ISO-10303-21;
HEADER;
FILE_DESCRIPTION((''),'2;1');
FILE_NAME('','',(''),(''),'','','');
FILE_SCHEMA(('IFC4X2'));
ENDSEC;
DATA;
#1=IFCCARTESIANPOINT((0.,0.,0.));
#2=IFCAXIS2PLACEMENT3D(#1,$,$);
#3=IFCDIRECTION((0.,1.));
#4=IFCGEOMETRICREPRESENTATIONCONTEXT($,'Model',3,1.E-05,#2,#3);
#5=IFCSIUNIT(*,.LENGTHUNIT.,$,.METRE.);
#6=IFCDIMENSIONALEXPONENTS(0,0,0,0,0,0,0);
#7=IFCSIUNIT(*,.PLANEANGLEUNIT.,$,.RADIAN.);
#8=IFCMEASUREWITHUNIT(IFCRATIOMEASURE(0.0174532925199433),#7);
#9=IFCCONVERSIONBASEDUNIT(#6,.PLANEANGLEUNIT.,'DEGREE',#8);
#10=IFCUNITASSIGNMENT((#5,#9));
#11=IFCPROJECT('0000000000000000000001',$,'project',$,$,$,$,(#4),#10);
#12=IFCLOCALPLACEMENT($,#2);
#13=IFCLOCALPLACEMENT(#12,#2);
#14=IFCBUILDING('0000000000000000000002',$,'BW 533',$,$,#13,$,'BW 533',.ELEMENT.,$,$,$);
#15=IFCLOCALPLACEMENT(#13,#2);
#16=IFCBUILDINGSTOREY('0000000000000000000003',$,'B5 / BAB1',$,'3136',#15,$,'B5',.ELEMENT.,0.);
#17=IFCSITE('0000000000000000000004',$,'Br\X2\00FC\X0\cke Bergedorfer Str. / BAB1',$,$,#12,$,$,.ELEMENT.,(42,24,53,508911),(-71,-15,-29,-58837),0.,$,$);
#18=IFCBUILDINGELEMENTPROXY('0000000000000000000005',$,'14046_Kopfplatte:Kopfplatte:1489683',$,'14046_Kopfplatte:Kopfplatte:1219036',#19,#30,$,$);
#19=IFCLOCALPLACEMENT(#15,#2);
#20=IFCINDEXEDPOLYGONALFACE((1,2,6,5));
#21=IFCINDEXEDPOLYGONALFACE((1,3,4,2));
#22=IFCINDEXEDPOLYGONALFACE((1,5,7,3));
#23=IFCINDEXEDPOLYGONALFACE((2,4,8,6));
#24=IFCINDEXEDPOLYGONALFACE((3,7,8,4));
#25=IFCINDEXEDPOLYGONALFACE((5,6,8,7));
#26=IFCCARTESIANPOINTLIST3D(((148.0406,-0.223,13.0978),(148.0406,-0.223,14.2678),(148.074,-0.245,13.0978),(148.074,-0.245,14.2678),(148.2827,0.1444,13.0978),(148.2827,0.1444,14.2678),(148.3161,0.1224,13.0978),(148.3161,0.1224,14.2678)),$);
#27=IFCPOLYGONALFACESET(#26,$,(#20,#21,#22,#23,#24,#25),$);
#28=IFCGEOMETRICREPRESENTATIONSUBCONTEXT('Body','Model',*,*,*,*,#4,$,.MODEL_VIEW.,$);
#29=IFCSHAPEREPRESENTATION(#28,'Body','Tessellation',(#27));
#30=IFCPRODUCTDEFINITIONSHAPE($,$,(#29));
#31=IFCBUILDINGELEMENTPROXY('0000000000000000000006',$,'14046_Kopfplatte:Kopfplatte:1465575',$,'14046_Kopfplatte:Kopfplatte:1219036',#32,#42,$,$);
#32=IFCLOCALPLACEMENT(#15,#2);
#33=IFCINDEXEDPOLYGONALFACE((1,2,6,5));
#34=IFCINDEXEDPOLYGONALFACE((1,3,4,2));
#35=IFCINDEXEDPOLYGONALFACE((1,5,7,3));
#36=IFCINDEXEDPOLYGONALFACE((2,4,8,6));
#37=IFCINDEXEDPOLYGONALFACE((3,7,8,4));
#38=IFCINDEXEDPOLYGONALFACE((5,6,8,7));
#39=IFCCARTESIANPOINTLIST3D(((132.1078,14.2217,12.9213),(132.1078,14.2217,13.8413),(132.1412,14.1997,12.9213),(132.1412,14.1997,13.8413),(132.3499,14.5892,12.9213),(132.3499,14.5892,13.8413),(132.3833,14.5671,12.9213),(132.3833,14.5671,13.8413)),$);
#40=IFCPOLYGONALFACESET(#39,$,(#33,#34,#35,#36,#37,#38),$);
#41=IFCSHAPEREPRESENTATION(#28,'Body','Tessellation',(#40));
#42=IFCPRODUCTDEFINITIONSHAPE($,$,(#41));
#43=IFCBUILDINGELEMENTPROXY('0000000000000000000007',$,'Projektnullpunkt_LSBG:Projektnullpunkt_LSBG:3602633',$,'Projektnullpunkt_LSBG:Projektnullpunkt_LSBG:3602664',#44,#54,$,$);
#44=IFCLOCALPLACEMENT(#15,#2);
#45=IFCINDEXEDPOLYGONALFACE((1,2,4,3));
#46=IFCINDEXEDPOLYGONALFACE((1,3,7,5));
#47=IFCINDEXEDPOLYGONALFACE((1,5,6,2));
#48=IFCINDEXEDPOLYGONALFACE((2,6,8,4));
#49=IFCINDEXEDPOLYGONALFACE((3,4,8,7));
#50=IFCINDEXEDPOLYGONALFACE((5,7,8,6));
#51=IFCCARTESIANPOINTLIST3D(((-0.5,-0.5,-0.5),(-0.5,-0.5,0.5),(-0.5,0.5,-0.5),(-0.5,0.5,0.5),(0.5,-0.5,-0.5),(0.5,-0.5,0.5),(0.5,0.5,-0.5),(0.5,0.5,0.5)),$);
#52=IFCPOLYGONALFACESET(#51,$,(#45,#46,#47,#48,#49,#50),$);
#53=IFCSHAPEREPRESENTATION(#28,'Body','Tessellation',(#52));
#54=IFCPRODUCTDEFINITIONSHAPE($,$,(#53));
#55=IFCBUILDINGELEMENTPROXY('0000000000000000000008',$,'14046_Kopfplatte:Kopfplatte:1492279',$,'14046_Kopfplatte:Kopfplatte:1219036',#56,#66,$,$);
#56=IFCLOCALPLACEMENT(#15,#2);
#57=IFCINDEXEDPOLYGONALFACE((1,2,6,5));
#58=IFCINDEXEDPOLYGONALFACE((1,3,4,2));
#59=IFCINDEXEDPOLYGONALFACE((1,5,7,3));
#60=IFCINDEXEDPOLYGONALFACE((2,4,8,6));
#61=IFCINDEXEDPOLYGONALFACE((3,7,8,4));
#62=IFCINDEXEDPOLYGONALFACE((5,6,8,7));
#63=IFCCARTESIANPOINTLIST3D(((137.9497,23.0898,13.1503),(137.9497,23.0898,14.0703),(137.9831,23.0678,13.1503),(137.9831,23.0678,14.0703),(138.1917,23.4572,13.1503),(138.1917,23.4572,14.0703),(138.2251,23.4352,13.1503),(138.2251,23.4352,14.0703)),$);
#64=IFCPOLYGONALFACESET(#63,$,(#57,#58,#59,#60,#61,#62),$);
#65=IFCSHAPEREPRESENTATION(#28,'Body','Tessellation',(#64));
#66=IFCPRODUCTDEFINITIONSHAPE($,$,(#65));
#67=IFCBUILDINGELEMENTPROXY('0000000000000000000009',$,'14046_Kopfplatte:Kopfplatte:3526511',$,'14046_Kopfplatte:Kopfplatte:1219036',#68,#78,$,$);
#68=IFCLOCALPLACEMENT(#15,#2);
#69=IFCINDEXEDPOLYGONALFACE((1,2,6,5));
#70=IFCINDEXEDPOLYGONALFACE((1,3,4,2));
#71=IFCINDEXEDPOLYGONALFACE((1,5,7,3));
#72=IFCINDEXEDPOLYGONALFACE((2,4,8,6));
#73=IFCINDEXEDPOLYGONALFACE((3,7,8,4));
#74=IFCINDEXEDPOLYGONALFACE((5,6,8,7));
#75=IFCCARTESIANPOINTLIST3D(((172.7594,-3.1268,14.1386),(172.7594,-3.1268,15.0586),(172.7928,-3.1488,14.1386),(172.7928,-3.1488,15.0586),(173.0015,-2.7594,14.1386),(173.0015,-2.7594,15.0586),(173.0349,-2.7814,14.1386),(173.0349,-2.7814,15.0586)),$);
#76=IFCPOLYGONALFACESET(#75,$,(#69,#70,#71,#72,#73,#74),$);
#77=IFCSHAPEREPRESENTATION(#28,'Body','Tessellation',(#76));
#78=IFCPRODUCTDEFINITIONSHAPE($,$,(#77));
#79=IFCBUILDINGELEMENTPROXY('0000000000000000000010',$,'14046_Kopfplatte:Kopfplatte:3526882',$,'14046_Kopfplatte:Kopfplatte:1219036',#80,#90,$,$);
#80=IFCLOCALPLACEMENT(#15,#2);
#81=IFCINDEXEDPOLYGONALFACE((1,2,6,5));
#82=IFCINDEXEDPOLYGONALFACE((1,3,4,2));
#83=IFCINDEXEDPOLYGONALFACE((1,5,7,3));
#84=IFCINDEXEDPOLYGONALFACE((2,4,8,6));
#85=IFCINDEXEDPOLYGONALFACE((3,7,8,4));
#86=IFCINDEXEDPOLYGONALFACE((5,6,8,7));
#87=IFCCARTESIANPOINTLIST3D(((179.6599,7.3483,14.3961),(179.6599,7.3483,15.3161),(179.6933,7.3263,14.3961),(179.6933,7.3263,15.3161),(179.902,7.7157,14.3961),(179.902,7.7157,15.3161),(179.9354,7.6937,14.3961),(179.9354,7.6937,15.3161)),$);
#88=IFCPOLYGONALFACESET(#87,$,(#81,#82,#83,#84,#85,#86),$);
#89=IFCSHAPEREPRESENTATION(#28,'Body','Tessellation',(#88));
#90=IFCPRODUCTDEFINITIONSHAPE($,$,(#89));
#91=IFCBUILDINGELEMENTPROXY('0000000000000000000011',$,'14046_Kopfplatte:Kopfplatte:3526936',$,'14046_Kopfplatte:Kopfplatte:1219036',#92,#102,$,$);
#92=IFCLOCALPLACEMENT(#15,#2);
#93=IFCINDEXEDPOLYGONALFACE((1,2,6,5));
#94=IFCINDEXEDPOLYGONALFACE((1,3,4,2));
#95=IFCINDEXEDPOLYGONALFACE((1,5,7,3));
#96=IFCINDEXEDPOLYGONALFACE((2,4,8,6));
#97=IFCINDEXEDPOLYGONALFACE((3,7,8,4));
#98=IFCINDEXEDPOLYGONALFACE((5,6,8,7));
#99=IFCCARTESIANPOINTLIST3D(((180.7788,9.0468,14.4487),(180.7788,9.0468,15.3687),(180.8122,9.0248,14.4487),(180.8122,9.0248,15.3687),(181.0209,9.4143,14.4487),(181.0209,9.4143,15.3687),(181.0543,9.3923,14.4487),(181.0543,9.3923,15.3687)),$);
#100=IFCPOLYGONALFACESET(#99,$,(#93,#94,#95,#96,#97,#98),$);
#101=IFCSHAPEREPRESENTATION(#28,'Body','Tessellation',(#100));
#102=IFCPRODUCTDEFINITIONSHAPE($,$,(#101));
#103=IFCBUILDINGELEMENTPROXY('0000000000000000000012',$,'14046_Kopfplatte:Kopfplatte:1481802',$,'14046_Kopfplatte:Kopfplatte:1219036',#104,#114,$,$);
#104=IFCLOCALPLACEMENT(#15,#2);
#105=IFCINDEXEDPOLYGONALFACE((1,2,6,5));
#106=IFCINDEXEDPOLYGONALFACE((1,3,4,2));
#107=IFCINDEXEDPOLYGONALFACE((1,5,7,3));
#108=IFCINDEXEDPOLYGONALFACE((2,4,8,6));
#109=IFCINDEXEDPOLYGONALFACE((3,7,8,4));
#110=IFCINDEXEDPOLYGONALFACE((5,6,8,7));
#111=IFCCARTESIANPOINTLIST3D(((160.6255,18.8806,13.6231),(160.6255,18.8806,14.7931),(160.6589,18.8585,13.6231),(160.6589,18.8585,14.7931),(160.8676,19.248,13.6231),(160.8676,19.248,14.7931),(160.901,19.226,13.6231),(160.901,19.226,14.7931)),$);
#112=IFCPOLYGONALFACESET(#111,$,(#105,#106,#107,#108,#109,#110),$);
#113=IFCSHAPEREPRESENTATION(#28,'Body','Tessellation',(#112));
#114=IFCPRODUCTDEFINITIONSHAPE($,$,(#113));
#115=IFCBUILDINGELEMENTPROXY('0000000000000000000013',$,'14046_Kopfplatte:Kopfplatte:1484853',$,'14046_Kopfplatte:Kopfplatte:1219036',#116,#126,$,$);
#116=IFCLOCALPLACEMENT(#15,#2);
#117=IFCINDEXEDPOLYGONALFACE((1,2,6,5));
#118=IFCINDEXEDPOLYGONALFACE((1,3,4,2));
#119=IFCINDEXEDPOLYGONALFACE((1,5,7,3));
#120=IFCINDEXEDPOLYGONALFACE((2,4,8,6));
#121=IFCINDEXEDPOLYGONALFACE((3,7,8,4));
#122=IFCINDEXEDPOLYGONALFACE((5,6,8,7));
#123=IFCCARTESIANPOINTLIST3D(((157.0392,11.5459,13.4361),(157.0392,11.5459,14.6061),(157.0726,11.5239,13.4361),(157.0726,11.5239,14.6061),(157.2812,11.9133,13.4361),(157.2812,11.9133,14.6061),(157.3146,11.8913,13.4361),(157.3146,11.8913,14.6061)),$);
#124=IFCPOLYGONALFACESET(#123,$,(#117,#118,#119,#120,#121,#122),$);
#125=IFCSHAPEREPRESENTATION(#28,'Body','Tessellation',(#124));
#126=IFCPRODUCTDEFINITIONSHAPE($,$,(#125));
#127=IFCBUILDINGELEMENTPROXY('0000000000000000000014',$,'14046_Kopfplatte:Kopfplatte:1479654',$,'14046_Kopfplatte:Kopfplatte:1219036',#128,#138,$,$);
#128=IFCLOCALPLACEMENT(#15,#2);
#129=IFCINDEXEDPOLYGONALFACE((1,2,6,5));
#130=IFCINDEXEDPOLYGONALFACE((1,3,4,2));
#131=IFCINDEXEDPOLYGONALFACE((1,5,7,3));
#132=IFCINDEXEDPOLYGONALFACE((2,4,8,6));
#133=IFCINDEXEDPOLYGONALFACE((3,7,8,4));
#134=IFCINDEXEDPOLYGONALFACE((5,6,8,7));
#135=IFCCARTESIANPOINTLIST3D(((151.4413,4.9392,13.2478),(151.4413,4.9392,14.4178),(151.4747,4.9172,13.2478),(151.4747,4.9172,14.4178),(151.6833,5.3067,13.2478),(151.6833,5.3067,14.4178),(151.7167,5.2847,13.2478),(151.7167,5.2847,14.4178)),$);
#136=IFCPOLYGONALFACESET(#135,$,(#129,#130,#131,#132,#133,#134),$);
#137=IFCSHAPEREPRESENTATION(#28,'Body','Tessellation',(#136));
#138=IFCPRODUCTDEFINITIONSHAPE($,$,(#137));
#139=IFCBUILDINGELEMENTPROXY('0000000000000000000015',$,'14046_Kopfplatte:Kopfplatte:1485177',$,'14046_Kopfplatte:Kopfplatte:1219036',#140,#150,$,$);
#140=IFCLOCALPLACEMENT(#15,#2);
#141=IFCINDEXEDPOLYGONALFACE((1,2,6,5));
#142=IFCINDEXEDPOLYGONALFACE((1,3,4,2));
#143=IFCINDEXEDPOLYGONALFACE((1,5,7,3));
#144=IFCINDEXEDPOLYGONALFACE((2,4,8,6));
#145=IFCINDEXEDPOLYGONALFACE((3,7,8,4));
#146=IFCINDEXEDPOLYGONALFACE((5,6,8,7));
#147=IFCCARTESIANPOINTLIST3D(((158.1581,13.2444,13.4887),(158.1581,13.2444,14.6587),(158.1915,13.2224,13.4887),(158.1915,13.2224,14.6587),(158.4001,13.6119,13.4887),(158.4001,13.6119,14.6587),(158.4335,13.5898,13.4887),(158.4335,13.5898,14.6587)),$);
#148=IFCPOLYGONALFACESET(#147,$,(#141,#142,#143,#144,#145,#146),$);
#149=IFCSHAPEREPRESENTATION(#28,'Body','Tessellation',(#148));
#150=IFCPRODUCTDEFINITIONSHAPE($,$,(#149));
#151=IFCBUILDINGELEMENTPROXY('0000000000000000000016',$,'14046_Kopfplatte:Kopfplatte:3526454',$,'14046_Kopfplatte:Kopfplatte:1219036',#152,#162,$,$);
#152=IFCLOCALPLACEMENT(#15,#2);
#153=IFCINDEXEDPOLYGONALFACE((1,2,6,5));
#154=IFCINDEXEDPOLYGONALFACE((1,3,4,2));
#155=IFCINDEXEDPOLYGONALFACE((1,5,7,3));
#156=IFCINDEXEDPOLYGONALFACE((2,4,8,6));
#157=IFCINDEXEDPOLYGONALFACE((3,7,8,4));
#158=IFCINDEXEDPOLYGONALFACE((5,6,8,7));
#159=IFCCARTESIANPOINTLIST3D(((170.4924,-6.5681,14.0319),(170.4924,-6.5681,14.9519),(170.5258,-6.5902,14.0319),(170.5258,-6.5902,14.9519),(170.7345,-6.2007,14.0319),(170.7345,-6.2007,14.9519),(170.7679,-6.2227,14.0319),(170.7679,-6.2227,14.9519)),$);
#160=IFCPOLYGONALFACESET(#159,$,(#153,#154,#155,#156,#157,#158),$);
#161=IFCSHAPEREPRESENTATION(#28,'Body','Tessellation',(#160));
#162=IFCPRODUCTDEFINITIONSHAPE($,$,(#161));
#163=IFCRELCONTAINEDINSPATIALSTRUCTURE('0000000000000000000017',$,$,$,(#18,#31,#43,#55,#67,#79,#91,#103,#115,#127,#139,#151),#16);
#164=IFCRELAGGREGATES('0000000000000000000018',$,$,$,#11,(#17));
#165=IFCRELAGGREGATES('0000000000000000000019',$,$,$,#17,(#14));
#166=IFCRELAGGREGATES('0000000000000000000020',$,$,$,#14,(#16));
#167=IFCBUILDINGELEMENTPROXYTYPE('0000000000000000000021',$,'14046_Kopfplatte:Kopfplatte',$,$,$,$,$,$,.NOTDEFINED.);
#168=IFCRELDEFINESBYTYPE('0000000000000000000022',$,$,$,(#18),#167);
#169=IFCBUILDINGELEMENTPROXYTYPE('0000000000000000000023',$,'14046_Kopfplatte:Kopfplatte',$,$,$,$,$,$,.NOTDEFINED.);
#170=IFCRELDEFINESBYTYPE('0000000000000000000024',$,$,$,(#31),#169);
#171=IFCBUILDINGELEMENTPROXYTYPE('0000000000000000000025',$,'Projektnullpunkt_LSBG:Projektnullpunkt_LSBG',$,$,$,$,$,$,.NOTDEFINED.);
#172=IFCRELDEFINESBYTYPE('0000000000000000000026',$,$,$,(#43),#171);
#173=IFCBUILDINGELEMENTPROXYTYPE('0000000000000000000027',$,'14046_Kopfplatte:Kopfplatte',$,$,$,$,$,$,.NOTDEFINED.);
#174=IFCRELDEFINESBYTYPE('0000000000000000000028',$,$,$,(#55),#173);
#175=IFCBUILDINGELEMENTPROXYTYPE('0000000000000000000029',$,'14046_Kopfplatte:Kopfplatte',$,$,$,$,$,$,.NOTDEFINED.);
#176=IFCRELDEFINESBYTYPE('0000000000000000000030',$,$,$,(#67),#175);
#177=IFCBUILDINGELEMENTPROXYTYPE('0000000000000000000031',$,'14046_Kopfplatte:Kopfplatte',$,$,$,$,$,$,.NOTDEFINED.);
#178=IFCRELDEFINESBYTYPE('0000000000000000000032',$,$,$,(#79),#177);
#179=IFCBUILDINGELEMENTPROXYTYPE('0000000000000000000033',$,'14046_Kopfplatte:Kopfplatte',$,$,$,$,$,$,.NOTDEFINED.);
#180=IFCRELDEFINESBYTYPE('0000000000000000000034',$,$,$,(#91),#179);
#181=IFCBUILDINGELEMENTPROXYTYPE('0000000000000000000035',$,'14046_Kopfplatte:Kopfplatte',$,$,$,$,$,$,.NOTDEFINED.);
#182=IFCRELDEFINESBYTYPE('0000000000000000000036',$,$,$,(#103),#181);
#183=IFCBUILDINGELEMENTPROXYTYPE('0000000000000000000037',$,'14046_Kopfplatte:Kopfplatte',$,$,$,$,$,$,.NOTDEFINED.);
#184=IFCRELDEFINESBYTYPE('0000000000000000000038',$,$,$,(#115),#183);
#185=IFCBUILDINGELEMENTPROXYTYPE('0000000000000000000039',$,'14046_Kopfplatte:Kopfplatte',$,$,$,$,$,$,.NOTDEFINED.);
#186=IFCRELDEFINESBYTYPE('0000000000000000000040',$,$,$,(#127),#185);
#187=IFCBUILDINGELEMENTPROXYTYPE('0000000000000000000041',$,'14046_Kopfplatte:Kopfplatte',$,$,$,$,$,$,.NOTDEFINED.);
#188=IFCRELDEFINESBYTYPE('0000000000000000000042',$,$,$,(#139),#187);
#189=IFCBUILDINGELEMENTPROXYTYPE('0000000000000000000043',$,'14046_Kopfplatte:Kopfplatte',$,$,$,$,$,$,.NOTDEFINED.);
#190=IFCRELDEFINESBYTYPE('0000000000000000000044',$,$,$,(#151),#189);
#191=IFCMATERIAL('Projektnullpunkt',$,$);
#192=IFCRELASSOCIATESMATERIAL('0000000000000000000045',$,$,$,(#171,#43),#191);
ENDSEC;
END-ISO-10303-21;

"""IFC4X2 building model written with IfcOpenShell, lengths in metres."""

from ifc_helpers import new_model, entity, si_unit, converted_unit, direction, frame, frame_2d, origin, origin_2d_with_axis, place, context, subcontext, project, spatial, rectangle, extrude, source, transform, mapped, material, type_object, type_shapes, element, save


model = new_model("IFC4X2")

# Units and contexts
model_context = context("Model", 3, precision=1e-05, world=origin(), true_north=direction((0.0, 1.0)))
body_context = subcontext(model_context, "Body", "Model", "MODEL_VIEW")
ifc_project = project(units=[si_unit("LENGTHUNIT", "METRE"), converted_unit("PLANEANGLEUNIT", "DEGREE", entity("IfcRatioMeasure", 0.0174532925199433), si_unit("PLANEANGLEUNIT", "RADIAN"), dimensions=[0, 0, 0, 0, 0, 0, 0])], contexts=[model_context])

# Site, building, storey
site_placement = place(None, origin())
site = spatial("IfcSite", under=ifc_project, at=site_placement, Name="Brücke Bergedorfer Str. / BAB1", CompositionType="ELEMENT", RefLatitude=(42, 24, 53, 508911), RefLongitude=(-71, -15, -29, -58837), RefElevation=0.0)
building_placement = place(site_placement, origin())
building = spatial("IfcBuilding", under=site, at=building_placement, Name="BW 533", LongName="BW 533", CompositionType="ELEMENT")
storey_placement = place(building_placement, origin())
storey = spatial("IfcBuildingStorey", under=building, at=storey_placement, Name="B5 / BAB1", ObjectType="3136", LongName="B5", CompositionType="ELEMENT", Elevation=0.0)

# Building element proxies
building_element_proxy_type_1 = type_object("IfcBuildingElementProxyType", Name="14046_Kopfplatte:Kopfplatte", PredefinedType="NOTDEFINED")
shared_shape_1 = source(origin(), body_context, "Body", "SweptSolid", [
    extrude(rectangle(XDim=0.04, YDim=0.44, at=frame_2d((0.0, 0.0), x_axis=(1.0, 0.0))), frame((148.1784, -0.0503, 13.0978), z_axis=(0.0, 0.0, 1.0), x_axis=(0.835088, -0.550116, 0.0)), (0.0, 0.0, 1.0), 1.17),
])
type_shapes(building_element_proxy_type_1, [shared_shape_1])
proxy_1_placement = place(storey_placement, origin())
element("IfcBuildingElementProxy", 1, at=proxy_1_placement, inside=storey, type_object=building_element_proxy_type_1, Name="14046_Kopfplatte:Kopfplatte:1489683", ObjectType="14046_Kopfplatte:Kopfplatte:1219036", context=body_context, shape_type="MappedRepresentation", body=[
    mapped(shared_shape_1, transform((0.0, 0.0, 0.0), scale=1.0)),
])
building_element_proxy_type_2 = type_object("IfcBuildingElementProxyType", Name="14046_Kopfplatte:Kopfplatte", PredefinedType="NOTDEFINED")
shared_shape_2 = source(origin(), body_context, "Body", "SweptSolid", [
    extrude(rectangle(XDim=0.04, YDim=0.44, at=frame_2d((0.0, 0.0), x_axis=(1.0, 0.0))), frame((132.2456, 14.3944, 12.9213), z_axis=(0.0, 0.0, 1.0), x_axis=(-0.835088, 0.550116, 0.0)), (0.0, 0.0, 1.0), 0.92),
])
type_shapes(building_element_proxy_type_2, [shared_shape_2])
proxy_2_placement = place(storey_placement, origin())
element("IfcBuildingElementProxy", 2, at=proxy_2_placement, inside=storey, type_object=building_element_proxy_type_2, Name="14046_Kopfplatte:Kopfplatte:1465575", ObjectType="14046_Kopfplatte:Kopfplatte:1219036", context=body_context, shape_type="MappedRepresentation", body=[
    mapped(shared_shape_2, transform((0.0, 0.0, 0.0), scale=1.0)),
])
ifc_material_1 = material(Name="Projektnullpunkt")
building_element_proxy_type_3 = type_object("IfcBuildingElementProxyType", Name="Projektnullpunkt_LSBG:Projektnullpunkt_LSBG", PredefinedType="NOTDEFINED", material=ifc_material_1)
shared_shape_3 = source(origin(), body_context, "Body", "SweptSolid", [
    extrude(rectangle(XDim=1.0, YDim=1.0, at=origin_2d_with_axis()), frame((0.0, 0.0, -0.5), z_axis=(0.0, 0.0, 1.0), x_axis=(-1.0, 0.0, 0.0)), (0.0, 0.0, 1.0), 1.0),
])
type_shapes(building_element_proxy_type_3, [shared_shape_3])
proxy_3_placement = place(storey_placement, origin())
element("IfcBuildingElementProxy", 3, at=proxy_3_placement, inside=storey, type_object=building_element_proxy_type_3, material=ifc_material_1, Name="Projektnullpunkt_LSBG:Projektnullpunkt_LSBG:3602633", ObjectType="Projektnullpunkt_LSBG:Projektnullpunkt_LSBG:3602664", context=body_context, shape_type="MappedRepresentation", body=[
    mapped(shared_shape_3, transform((0.0, 0.0, 0.0), scale=1.0)),
])
building_element_proxy_type_4 = type_object("IfcBuildingElementProxyType", Name="14046_Kopfplatte:Kopfplatte", PredefinedType="NOTDEFINED")
shared_shape_4 = source(origin(), body_context, "Body", "SweptSolid", [
    extrude(rectangle(XDim=0.04, YDim=0.44, at=frame_2d((0.0, 0.0), x_axis=(1.0, 0.0))), frame((138.0874, 23.2625, 13.1503), z_axis=(0.0, 0.0, 1.0), x_axis=(-0.835088, 0.550116, 0.0)), (0.0, 0.0, 1.0), 0.92),
])
type_shapes(building_element_proxy_type_4, [shared_shape_4])
proxy_4_placement = place(storey_placement, origin())
element("IfcBuildingElementProxy", 4, at=proxy_4_placement, inside=storey, type_object=building_element_proxy_type_4, Name="14046_Kopfplatte:Kopfplatte:1492279", ObjectType="14046_Kopfplatte:Kopfplatte:1219036", context=body_context, shape_type="MappedRepresentation", body=[
    mapped(shared_shape_4, transform((0.0, 0.0, 0.0), scale=1.0)),
])
building_element_proxy_type_5 = type_object("IfcBuildingElementProxyType", Name="14046_Kopfplatte:Kopfplatte", PredefinedType="NOTDEFINED")
shared_shape_5 = source(origin(), body_context, "Body", "SweptSolid", [
    extrude(rectangle(XDim=0.04, YDim=0.44, at=frame_2d((0.0, 0.0), x_axis=(1.0, 0.0))), frame((172.8971, -2.9541, 14.1386), z_axis=(0.0, 0.0, 1.0), x_axis=(0.835088, -0.550116, 0.0)), (0.0, 0.0, 1.0), 0.92),
])
type_shapes(building_element_proxy_type_5, [shared_shape_5])
proxy_5_placement = place(storey_placement, origin())
element("IfcBuildingElementProxy", 5, at=proxy_5_placement, inside=storey, type_object=building_element_proxy_type_5, Name="14046_Kopfplatte:Kopfplatte:3526511", ObjectType="14046_Kopfplatte:Kopfplatte:1219036", context=body_context, shape_type="MappedRepresentation", body=[
    mapped(shared_shape_5, transform((0.0, 0.0, 0.0), scale=1.0)),
])
building_element_proxy_type_6 = type_object("IfcBuildingElementProxyType", Name="14046_Kopfplatte:Kopfplatte", PredefinedType="NOTDEFINED")
shared_shape_6 = source(origin(), body_context, "Body", "SweptSolid", [
    extrude(rectangle(XDim=0.04, YDim=0.44, at=frame_2d((0.0, 0.0), x_axis=(1.0, 0.0))), frame((179.7976, 7.521, 14.3961), z_axis=(0.0, 0.0, 1.0), x_axis=(0.835088, -0.550116, 0.0)), (0.0, 0.0, 1.0), 0.92),
])
type_shapes(building_element_proxy_type_6, [shared_shape_6])
proxy_6_placement = place(storey_placement, origin())
element("IfcBuildingElementProxy", 6, at=proxy_6_placement, inside=storey, type_object=building_element_proxy_type_6, Name="14046_Kopfplatte:Kopfplatte:3526882", ObjectType="14046_Kopfplatte:Kopfplatte:1219036", context=body_context, shape_type="MappedRepresentation", body=[
    mapped(shared_shape_6, transform((0.0, 0.0, 0.0), scale=1.0)),
])
building_element_proxy_type_7 = type_object("IfcBuildingElementProxyType", Name="14046_Kopfplatte:Kopfplatte", PredefinedType="NOTDEFINED")
shared_shape_7 = source(origin(), body_context, "Body", "SweptSolid", [
    extrude(rectangle(XDim=0.04, YDim=0.44, at=frame_2d((0.0, 0.0), x_axis=(1.0, 0.0))), frame((180.9165, 9.2195, 14.4487), z_axis=(0.0, 0.0, 1.0), x_axis=(0.835088, -0.550116, 0.0)), (0.0, 0.0, 1.0), 0.92),
])
type_shapes(building_element_proxy_type_7, [shared_shape_7])
proxy_7_placement = place(storey_placement, origin())
element("IfcBuildingElementProxy", 7, at=proxy_7_placement, inside=storey, type_object=building_element_proxy_type_7, Name="14046_Kopfplatte:Kopfplatte:3526936", ObjectType="14046_Kopfplatte:Kopfplatte:1219036", context=body_context, shape_type="MappedRepresentation", body=[
    mapped(shared_shape_7, transform((0.0, 0.0, 0.0), scale=1.0)),
])
building_element_proxy_type_8 = type_object("IfcBuildingElementProxyType", Name="14046_Kopfplatte:Kopfplatte", PredefinedType="NOTDEFINED")
shared_shape_8 = source(origin(), body_context, "Body", "SweptSolid", [
    extrude(rectangle(XDim=0.04, YDim=0.44, at=frame_2d((0.0, 0.0), x_axis=(1.0, 0.0))), frame((160.7633, 19.0533, 13.6231), z_axis=(0.0, 0.0, 1.0), x_axis=(0.835088, -0.550116, 0.0)), (0.0, 0.0, 1.0), 1.17),
])
type_shapes(building_element_proxy_type_8, [shared_shape_8])
proxy_8_placement = place(storey_placement, origin())
element("IfcBuildingElementProxy", 8, at=proxy_8_placement, inside=storey, type_object=building_element_proxy_type_8, Name="14046_Kopfplatte:Kopfplatte:1481802", ObjectType="14046_Kopfplatte:Kopfplatte:1219036", context=body_context, shape_type="MappedRepresentation", body=[
    mapped(shared_shape_8, transform((0.0, 0.0, 0.0), scale=1.0)),
])
building_element_proxy_type_9 = type_object("IfcBuildingElementProxyType", Name="14046_Kopfplatte:Kopfplatte", PredefinedType="NOTDEFINED")
shared_shape_9 = source(origin(), body_context, "Body", "SweptSolid", [
    extrude(rectangle(XDim=0.04, YDim=0.44, at=frame_2d((0.0, 0.0), x_axis=(1.0, 0.0))), frame((157.1769, 11.7186, 13.4361), z_axis=(0.0, 0.0, 1.0), x_axis=(-0.835088, 0.550116, 0.0)), (0.0, 0.0, 1.0), 1.17),
])
type_shapes(building_element_proxy_type_9, [shared_shape_9])
proxy_9_placement = place(storey_placement, origin())
element("IfcBuildingElementProxy", 9, at=proxy_9_placement, inside=storey, type_object=building_element_proxy_type_9, Name="14046_Kopfplatte:Kopfplatte:1484853", ObjectType="14046_Kopfplatte:Kopfplatte:1219036", context=body_context, shape_type="MappedRepresentation", body=[
    mapped(shared_shape_9, transform((0.0, 0.0, 0.0), scale=1.0)),
])
building_element_proxy_type_10 = type_object("IfcBuildingElementProxyType", Name="14046_Kopfplatte:Kopfplatte", PredefinedType="NOTDEFINED")
shared_shape_10 = source(origin(), body_context, "Body", "SweptSolid", [
    extrude(rectangle(XDim=0.04, YDim=0.44, at=origin_2d_with_axis()), frame((151.579, 5.112, 13.2478), z_axis=(0.0, 0.0, 1.0), x_axis=(0.835088, -0.550116, 0.0)), (0.0, 0.0, 1.0), 1.17),
])
type_shapes(building_element_proxy_type_10, [shared_shape_10])
proxy_10_placement = place(storey_placement, origin())
element("IfcBuildingElementProxy", 10, at=proxy_10_placement, inside=storey, type_object=building_element_proxy_type_10, Name="14046_Kopfplatte:Kopfplatte:1479654", ObjectType="14046_Kopfplatte:Kopfplatte:1219036", context=body_context, shape_type="MappedRepresentation", body=[
    mapped(shared_shape_10, transform((0.0, 0.0, 0.0), scale=1.0)),
])
building_element_proxy_type_11 = type_object("IfcBuildingElementProxyType", Name="14046_Kopfplatte:Kopfplatte", PredefinedType="NOTDEFINED")
shared_shape_11 = source(origin(), body_context, "Body", "SweptSolid", [
    extrude(rectangle(XDim=0.04, YDim=0.44, at=frame_2d((0.0, 0.0), x_axis=(1.0, 0.0))), frame((158.2958, 13.4171, 13.4887), z_axis=(0.0, 0.0, 1.0), x_axis=(-0.835088, 0.550116, 0.0)), (0.0, 0.0, 1.0), 1.17),
])
type_shapes(building_element_proxy_type_11, [shared_shape_11])
proxy_11_placement = place(storey_placement, origin())
element("IfcBuildingElementProxy", 11, at=proxy_11_placement, inside=storey, type_object=building_element_proxy_type_11, Name="14046_Kopfplatte:Kopfplatte:1485177", ObjectType="14046_Kopfplatte:Kopfplatte:1219036", context=body_context, shape_type="MappedRepresentation", body=[
    mapped(shared_shape_11, transform((0.0, 0.0, 0.0), scale=1.0)),
])
building_element_proxy_type_12 = type_object("IfcBuildingElementProxyType", Name="14046_Kopfplatte:Kopfplatte", PredefinedType="NOTDEFINED")
shared_shape_12 = source(origin(), body_context, "Body", "SweptSolid", [
    extrude(rectangle(XDim=0.04, YDim=0.44, at=frame_2d((0.0, 0.0), x_axis=(1.0, 0.0))), frame((170.6301, -6.3954, 14.0319), z_axis=(0.0, 0.0, 1.0), x_axis=(0.835088, -0.550116, 0.0)), (0.0, 0.0, 1.0), 0.92),
])
type_shapes(building_element_proxy_type_12, [shared_shape_12])
proxy_12_placement = place(storey_placement, origin())
element("IfcBuildingElementProxy", 12, at=proxy_12_placement, inside=storey, type_object=building_element_proxy_type_12, Name="14046_Kopfplatte:Kopfplatte:3526454", ObjectType="14046_Kopfplatte:Kopfplatte:1219036", context=body_context, shape_type="MappedRepresentation", body=[
    mapped(shared_shape_12, transform((0.0, 0.0, 0.0), scale=1.0)),
])

save(model, "model.ifc")
